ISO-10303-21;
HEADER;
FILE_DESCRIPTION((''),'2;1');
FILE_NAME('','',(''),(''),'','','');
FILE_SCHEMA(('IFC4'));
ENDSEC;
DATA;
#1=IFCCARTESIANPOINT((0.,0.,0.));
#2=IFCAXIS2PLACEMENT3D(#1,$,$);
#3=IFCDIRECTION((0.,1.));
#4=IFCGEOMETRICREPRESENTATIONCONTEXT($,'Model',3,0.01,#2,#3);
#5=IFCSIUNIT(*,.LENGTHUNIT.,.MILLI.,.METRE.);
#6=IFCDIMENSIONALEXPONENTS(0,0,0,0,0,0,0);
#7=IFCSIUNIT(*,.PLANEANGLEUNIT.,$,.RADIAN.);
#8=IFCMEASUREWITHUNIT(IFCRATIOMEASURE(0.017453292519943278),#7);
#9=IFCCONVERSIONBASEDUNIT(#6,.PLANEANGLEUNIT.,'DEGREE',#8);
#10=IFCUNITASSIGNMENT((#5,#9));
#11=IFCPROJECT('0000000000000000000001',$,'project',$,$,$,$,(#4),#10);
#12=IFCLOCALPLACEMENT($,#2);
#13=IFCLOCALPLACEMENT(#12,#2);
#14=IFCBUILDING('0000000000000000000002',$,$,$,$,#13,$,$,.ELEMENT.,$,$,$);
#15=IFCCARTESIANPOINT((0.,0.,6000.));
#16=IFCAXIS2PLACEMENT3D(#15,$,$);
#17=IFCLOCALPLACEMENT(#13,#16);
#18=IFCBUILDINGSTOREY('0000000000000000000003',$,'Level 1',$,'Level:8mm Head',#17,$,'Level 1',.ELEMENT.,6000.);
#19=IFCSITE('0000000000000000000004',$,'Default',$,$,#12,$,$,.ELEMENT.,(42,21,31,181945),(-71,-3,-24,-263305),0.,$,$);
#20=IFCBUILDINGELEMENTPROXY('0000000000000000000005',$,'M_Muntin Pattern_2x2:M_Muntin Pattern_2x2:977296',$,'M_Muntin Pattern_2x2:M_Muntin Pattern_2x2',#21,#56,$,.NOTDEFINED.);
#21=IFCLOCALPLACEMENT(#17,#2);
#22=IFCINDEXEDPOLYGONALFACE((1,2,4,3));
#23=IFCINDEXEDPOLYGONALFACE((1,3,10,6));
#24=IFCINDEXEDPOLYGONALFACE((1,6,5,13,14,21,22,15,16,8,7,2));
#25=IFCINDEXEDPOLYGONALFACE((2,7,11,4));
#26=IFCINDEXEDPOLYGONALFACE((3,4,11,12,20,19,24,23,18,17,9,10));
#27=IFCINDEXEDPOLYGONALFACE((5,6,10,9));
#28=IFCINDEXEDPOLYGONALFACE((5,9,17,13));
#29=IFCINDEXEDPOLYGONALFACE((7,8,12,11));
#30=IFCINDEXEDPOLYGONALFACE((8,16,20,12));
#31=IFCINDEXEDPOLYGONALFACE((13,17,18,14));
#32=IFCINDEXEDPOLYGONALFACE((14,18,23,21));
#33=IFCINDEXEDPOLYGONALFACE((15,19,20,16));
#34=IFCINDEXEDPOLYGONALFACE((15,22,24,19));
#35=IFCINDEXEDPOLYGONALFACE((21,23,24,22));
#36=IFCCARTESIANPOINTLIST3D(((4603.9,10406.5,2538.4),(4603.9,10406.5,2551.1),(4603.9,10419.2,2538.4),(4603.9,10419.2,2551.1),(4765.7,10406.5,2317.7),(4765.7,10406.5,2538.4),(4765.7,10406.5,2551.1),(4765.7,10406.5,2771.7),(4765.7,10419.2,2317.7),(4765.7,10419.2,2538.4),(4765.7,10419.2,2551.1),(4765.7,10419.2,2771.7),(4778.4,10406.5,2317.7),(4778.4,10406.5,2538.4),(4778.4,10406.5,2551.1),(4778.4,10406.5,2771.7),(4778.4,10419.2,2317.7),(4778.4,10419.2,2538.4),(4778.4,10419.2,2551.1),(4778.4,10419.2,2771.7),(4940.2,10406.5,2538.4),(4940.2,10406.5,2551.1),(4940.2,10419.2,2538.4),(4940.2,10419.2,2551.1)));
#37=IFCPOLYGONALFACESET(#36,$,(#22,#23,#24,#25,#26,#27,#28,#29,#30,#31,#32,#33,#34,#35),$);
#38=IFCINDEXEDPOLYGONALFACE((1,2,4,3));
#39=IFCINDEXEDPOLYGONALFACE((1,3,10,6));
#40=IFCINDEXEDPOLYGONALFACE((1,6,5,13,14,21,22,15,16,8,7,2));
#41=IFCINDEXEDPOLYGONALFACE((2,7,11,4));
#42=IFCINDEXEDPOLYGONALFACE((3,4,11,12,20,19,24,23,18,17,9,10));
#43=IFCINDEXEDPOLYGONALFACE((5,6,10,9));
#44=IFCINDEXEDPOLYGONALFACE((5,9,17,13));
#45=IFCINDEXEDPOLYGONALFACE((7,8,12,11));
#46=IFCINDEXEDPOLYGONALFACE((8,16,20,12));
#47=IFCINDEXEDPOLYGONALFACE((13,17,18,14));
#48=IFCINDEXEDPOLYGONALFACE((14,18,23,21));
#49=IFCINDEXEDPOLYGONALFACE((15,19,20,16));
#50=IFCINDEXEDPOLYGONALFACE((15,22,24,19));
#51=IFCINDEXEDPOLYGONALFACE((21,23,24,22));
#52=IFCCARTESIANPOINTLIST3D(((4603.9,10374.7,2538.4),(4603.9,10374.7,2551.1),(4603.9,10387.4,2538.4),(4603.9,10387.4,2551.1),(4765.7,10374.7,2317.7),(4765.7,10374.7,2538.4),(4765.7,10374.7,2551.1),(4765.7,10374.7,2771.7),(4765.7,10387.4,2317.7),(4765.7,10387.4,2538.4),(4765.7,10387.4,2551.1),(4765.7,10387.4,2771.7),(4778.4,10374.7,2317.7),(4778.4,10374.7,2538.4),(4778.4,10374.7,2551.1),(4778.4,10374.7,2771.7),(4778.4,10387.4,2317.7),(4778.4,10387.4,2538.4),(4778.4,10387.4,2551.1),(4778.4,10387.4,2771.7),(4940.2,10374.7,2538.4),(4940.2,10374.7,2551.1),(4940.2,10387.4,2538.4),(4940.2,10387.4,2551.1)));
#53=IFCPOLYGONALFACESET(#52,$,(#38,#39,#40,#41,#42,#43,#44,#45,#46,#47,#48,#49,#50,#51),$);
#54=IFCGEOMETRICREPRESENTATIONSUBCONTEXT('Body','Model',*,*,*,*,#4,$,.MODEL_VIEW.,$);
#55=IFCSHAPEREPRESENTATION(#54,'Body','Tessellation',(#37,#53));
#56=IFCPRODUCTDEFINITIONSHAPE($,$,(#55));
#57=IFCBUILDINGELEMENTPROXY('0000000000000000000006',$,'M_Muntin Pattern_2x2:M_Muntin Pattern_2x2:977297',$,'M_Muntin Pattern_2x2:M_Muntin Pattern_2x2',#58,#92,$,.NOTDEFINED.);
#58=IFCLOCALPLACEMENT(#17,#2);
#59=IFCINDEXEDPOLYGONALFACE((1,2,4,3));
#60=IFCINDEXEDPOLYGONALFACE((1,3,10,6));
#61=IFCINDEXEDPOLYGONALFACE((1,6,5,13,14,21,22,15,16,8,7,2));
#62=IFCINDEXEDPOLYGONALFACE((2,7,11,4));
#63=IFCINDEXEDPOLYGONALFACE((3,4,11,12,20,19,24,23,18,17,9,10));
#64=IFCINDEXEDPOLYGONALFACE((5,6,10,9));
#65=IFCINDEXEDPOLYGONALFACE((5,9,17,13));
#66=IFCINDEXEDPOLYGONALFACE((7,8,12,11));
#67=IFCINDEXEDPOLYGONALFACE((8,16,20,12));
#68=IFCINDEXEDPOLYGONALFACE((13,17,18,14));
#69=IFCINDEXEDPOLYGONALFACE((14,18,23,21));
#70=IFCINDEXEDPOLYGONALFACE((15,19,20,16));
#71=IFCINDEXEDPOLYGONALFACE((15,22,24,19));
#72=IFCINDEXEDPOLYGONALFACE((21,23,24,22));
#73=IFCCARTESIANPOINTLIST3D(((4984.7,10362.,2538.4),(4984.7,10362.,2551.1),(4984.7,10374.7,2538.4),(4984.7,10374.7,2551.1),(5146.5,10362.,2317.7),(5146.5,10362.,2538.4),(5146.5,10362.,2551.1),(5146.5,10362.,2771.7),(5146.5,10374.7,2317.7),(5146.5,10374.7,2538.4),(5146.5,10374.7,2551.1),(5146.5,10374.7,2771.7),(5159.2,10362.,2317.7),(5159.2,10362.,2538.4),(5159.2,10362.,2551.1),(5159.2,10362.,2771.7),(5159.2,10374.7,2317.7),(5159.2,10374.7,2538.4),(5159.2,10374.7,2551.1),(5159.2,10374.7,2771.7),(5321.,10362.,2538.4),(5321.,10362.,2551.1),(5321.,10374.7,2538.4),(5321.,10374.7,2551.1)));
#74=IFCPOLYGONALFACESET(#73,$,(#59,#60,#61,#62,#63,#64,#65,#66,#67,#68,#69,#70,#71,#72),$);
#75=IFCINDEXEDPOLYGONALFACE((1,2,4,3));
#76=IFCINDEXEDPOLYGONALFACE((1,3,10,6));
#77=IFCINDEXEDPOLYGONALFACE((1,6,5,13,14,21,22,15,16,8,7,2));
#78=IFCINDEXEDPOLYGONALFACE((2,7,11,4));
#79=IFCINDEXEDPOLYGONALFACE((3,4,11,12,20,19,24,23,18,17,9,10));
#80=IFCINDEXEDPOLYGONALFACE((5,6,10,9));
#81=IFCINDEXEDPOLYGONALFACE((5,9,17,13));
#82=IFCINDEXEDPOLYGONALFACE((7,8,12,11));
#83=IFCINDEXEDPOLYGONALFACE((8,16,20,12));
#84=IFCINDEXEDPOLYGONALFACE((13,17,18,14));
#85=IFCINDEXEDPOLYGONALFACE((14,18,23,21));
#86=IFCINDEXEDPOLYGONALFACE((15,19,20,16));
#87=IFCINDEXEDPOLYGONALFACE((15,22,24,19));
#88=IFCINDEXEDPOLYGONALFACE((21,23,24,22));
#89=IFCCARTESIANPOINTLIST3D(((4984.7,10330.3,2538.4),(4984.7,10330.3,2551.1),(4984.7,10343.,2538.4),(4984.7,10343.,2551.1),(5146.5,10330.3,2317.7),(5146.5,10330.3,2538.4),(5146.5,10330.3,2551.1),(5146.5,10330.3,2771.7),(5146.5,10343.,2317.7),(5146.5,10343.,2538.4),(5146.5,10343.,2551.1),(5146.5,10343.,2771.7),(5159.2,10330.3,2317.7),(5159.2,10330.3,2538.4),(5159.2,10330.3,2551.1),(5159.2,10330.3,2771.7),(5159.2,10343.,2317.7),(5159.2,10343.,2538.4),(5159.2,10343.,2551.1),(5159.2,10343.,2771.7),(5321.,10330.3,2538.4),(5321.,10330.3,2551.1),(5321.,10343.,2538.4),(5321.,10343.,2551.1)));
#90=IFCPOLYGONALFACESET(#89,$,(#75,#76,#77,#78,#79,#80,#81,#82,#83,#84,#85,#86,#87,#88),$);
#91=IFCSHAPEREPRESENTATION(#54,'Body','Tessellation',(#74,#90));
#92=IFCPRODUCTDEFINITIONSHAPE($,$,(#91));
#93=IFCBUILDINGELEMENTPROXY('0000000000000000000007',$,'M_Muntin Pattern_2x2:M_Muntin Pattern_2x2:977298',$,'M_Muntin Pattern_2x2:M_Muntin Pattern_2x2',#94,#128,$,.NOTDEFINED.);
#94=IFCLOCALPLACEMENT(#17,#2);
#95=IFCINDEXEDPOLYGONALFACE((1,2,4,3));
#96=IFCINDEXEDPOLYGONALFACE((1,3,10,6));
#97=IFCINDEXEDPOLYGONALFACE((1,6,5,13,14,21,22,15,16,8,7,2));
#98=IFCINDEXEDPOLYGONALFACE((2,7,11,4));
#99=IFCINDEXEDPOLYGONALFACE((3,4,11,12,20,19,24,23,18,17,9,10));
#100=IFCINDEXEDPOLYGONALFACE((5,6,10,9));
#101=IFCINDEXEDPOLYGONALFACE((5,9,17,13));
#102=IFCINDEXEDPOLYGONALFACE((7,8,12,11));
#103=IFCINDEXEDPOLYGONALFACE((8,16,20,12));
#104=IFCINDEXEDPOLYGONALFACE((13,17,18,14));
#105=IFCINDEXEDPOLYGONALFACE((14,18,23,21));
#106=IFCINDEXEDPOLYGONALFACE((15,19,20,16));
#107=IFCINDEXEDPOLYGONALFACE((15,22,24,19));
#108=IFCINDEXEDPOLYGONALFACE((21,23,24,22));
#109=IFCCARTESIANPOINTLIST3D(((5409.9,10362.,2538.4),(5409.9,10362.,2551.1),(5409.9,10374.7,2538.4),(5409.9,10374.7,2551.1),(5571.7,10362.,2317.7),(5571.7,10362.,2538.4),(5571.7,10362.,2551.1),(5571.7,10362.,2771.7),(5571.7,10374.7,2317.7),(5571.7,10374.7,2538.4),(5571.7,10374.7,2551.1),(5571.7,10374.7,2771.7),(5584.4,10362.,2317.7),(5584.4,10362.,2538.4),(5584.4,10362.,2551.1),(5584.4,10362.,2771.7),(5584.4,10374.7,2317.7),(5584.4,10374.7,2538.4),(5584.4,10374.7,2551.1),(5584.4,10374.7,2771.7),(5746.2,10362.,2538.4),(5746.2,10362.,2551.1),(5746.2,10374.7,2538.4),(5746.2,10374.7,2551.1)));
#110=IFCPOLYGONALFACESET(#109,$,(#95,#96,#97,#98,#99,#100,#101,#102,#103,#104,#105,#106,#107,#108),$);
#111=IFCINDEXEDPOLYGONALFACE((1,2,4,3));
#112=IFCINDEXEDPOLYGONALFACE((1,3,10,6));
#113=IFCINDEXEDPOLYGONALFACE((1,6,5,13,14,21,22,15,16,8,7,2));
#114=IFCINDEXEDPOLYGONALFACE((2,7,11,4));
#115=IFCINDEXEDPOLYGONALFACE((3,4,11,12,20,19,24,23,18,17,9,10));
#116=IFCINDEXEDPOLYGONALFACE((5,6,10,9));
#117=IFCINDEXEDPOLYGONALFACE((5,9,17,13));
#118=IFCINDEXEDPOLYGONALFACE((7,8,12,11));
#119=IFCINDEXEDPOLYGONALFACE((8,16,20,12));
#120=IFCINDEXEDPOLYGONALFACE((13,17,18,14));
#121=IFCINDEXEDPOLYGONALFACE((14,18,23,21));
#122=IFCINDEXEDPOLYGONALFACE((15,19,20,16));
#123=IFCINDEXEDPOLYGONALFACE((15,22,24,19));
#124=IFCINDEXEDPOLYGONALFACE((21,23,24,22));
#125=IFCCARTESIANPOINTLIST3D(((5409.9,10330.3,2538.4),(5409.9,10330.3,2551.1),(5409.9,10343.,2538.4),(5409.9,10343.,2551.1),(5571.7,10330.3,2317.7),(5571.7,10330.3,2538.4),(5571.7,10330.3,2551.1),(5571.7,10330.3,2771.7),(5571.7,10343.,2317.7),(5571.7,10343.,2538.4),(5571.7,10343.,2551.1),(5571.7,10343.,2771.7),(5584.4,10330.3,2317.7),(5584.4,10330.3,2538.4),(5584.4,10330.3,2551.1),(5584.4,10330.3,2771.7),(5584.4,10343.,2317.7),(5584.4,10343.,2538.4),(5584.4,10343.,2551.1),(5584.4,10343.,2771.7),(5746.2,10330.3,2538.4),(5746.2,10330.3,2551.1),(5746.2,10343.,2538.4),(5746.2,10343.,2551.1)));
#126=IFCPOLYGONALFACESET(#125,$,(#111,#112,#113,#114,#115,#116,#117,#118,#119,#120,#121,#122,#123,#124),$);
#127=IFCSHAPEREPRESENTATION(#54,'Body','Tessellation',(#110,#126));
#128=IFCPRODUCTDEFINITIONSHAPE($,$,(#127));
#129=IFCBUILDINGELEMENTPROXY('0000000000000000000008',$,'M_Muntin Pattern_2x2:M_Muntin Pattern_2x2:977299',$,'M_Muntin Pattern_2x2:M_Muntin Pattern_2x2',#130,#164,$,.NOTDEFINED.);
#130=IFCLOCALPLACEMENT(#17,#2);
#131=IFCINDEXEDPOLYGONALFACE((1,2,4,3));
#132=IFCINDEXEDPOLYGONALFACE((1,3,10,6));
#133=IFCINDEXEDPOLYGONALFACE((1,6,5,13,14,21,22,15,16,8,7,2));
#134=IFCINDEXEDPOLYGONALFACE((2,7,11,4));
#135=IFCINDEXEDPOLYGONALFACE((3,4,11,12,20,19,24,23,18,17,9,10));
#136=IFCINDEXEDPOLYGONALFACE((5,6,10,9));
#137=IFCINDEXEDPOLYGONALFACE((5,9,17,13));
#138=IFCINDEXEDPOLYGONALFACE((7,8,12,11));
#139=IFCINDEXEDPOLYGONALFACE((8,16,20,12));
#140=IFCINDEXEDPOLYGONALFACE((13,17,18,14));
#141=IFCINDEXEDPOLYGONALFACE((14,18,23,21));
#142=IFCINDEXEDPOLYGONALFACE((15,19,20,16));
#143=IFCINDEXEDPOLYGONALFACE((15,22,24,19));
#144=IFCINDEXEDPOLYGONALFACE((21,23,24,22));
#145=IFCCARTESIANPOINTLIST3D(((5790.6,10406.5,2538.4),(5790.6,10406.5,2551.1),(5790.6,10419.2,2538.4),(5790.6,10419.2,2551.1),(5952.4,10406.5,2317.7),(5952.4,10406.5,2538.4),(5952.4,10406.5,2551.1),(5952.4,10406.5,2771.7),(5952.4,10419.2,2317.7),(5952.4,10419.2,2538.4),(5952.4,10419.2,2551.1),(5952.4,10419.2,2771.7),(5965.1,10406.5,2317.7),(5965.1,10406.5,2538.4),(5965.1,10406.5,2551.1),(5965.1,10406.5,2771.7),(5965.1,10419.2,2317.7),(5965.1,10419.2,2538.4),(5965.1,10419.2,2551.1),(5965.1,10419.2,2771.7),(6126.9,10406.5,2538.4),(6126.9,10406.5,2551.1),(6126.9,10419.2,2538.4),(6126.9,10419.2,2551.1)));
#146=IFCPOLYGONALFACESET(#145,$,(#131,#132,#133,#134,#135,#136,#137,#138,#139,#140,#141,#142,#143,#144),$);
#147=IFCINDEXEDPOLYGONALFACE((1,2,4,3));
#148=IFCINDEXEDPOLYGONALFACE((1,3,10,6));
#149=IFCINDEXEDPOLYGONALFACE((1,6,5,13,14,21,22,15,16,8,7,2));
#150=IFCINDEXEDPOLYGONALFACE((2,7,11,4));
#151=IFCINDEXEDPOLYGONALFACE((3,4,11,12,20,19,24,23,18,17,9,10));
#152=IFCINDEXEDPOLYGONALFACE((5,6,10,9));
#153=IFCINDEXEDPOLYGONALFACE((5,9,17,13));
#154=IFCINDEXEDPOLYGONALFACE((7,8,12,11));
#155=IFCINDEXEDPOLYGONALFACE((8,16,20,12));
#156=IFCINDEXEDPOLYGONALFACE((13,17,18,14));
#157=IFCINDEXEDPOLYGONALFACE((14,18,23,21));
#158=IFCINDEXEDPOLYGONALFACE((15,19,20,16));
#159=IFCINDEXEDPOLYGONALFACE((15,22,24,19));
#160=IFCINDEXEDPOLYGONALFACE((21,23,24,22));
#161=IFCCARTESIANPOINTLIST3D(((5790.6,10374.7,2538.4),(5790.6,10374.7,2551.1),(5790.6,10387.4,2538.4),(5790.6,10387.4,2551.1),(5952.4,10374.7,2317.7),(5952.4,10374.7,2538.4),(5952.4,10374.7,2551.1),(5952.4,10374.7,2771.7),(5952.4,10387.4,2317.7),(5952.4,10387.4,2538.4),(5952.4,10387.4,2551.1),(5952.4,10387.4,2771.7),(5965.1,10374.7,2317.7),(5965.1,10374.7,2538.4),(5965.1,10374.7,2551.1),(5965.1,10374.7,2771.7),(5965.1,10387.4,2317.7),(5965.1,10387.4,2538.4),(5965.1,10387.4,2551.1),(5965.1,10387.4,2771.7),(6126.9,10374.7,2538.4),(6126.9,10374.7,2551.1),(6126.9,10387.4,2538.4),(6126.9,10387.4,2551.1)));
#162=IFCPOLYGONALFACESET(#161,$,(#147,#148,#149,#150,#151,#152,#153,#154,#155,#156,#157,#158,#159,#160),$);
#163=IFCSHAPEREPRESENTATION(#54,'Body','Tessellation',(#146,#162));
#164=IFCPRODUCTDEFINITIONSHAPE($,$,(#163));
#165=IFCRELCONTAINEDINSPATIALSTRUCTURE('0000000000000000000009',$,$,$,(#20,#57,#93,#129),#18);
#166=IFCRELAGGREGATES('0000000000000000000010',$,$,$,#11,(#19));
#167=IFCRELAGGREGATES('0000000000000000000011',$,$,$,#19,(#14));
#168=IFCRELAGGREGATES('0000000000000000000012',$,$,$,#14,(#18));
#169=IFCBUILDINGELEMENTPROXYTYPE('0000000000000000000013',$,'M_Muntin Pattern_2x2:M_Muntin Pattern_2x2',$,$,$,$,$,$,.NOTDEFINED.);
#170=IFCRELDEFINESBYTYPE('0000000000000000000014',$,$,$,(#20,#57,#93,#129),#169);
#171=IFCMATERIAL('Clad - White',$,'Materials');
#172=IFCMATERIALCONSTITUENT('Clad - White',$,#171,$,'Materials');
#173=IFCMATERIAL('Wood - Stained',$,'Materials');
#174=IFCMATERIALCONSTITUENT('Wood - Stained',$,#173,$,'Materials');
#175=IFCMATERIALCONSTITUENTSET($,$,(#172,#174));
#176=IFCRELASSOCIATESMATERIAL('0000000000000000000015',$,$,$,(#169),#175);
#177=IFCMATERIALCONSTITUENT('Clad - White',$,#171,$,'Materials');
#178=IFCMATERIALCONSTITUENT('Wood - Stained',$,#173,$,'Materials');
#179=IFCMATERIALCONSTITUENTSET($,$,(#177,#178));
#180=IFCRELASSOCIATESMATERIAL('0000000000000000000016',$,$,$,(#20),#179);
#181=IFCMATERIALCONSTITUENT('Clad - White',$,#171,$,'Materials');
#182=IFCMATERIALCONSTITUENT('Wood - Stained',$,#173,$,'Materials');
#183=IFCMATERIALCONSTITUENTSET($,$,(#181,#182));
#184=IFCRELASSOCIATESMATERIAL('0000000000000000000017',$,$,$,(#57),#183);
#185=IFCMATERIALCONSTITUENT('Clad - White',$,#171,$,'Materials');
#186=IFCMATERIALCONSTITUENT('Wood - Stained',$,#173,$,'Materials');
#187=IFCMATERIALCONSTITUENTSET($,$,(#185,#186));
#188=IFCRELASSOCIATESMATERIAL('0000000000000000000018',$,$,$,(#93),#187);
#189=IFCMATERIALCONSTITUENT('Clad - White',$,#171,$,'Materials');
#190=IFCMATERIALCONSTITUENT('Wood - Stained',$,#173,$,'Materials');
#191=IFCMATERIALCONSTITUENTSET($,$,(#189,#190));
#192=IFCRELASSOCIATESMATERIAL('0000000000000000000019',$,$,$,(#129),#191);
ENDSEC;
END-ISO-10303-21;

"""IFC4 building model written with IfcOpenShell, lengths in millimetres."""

from ifc_helpers import new_model, entity, si_unit, converted_unit, direction, frame, origin, place, context, subcontext, project, spatial, indexed_curve, outline, extrude, source, transform, mapped, material, constituent, constituent_set, type_object, type_shapes, element, save


model = new_model("IFC4")

# Units and contexts
model_context = context("Model", 3, precision=0.01, world=origin(), true_north=direction((0.0, 1.0)))
body_context = subcontext(model_context, "Body", "Model", "MODEL_VIEW")
ifc_project = project(units=[si_unit("LENGTHUNIT", "METRE", prefix="MILLI"), converted_unit("PLANEANGLEUNIT", "DEGREE", entity("IfcRatioMeasure", 0.017453292519943278), si_unit("PLANEANGLEUNIT", "RADIAN"), dimensions=[0, 0, 0, 0, 0, 0, 0])], contexts=[model_context])

# Site, building, storey
site_placement = place(None, origin())
site = spatial("IfcSite", under=ifc_project, at=site_placement, Name="Default", CompositionType="ELEMENT", RefLatitude=(42, 21, 31, 181945), RefLongitude=(-71, -3, -24, -263305), RefElevation=0.0)
building_placement = place(site_placement, origin())
building = spatial("IfcBuilding", under=site, at=building_placement, CompositionType="ELEMENT")
storey_placement = place(building_placement, frame((0.0, 0.0, 6000.0)))
storey = spatial("IfcBuildingStorey", under=building, at=storey_placement, Name="Level 1", ObjectType="Level:8mm Head", LongName="Level 1", CompositionType="ELEMENT", Elevation=6000.0)

# Building element proxies
ifc_material_1 = material(Name="Clad - White", Category="Materials")
ifc_constituent_1 = constituent(ifc_material_1, Name="Clad - White", Category="Materials")
ifc_material_2 = material(Name="Wood - Stained", Category="Materials")
ifc_constituent_2 = constituent(ifc_material_2, Name="Wood - Stained", Category="Materials")
ifc_constituent_set_1 = constituent_set(constituents=[ifc_constituent_1, ifc_constituent_2])
ifc_constituent_3 = constituent(ifc_material_1, Name="Clad - White", Category="Materials")
ifc_constituent_4 = constituent(ifc_material_2, Name="Wood - Stained", Category="Materials")
ifc_constituent_set_2 = constituent_set(constituents=[ifc_constituent_3, ifc_constituent_4])
building_element_proxy_type_1 = type_object("IfcBuildingElementProxyType", Name="M_Muntin Pattern_2x2:M_Muntin Pattern_2x2", PredefinedType="NOTDEFINED", material=ifc_constituent_set_2)
shared_shape_1 = source(origin(), body_context, "Body", "SweptSolid", [
    extrude(outline(indexed_curve([(6.4, -6.4), (227.0, -6.4), (227.0, 6.3), (6.4, 6.3), (6.4, 168.2), (-6.3, 168.2), (-6.3, 6.3), (-227.0, 6.3), (-227.0, -6.4), (-6.3, -6.4), (-6.3, -168.1), (6.4, -168.1), (6.4, -6.4)], self_intersect=False)), frame((0.0, 9.5, 227.0), z_axis=(0.0, 1.0, 0.0), x_axis=(0.0, 0.0, 1.0)), (0.0, 0.0, 1.0), 12.7),
    extrude(outline(indexed_curve([(6.4, -6.4), (227.0, -6.4), (227.0, 6.3), (6.4, 6.3), (6.4, 168.2), (-6.3, 168.2), (-6.3, 6.3), (-227.0, 6.3), (-227.0, -6.4), (-6.3, -6.4), (-6.3, -168.1), (6.4, -168.1), (6.4, -6.4)], self_intersect=False)), frame((0.0, -22.2, 227.0), z_axis=(0.0, 1.0, 0.0), x_axis=(0.0, 0.0, 1.0)), (0.0, 0.0, 1.0), 12.7),
])
type_shapes(building_element_proxy_type_1, [shared_shape_1])
proxy_1_placement = place(storey_placement, frame((4772.1, 10396.9, 2317.7)))
element("IfcBuildingElementProxy", 1, at=proxy_1_placement, inside=storey, type_object=building_element_proxy_type_1, material=ifc_constituent_set_1, Name="M_Muntin Pattern_2x2:M_Muntin Pattern_2x2:977296", ObjectType="M_Muntin Pattern_2x2:M_Muntin Pattern_2x2", PredefinedType="NOTDEFINED", context=body_context, shape_type="MappedRepresentation", body=[
    mapped(shared_shape_1, transform((0.0, 0.0, 0.0), scale=1.0)),
])
ifc_constituent_5 = constituent(ifc_material_1, Name="Clad - White", Category="Materials")
ifc_constituent_6 = constituent(ifc_material_2, Name="Wood - Stained", Category="Materials")
ifc_constituent_set_3 = constituent_set(constituents=[ifc_constituent_5, ifc_constituent_6])
proxy_2_placement = place(storey_placement, frame((5152.8, 10352.5, 2317.7)))
element("IfcBuildingElementProxy", 2, at=proxy_2_placement, inside=storey, type_object=building_element_proxy_type_1, material=ifc_constituent_set_3, Name="M_Muntin Pattern_2x2:M_Muntin Pattern_2x2:977297", ObjectType="M_Muntin Pattern_2x2:M_Muntin Pattern_2x2", PredefinedType="NOTDEFINED", context=body_context, shape_type="MappedRepresentation", body=[
    mapped(shared_shape_1, transform((0.0, 0.0, 0.0), scale=1.0)),
])
ifc_constituent_7 = constituent(ifc_material_1, Name="Clad - White", Category="Materials")
ifc_constituent_8 = constituent(ifc_material_2, Name="Wood - Stained", Category="Materials")
ifc_constituent_set_4 = constituent_set(constituents=[ifc_constituent_7, ifc_constituent_8])
proxy_3_placement = place(storey_placement, frame((5578.0, 10352.5, 2317.7)))
element("IfcBuildingElementProxy", 3, at=proxy_3_placement, inside=storey, type_object=building_element_proxy_type_1, material=ifc_constituent_set_4, Name="M_Muntin Pattern_2x2:M_Muntin Pattern_2x2:977298", ObjectType="M_Muntin Pattern_2x2:M_Muntin Pattern_2x2", PredefinedType="NOTDEFINED", context=body_context, shape_type="MappedRepresentation", body=[
    mapped(shared_shape_1, transform((0.0, 0.0, 0.0), scale=1.0)),
])
ifc_constituent_9 = constituent(ifc_material_1, Name="Clad - White", Category="Materials")
ifc_constituent_10 = constituent(ifc_material_2, Name="Wood - Stained", Category="Materials")
ifc_constituent_set_5 = constituent_set(constituents=[ifc_constituent_9, ifc_constituent_10])
proxy_4_placement = place(storey_placement, frame((5958.8, 10396.9, 2317.7)))
element("IfcBuildingElementProxy", 4, at=proxy_4_placement, inside=storey, type_object=building_element_proxy_type_1, material=ifc_constituent_set_5, Name="M_Muntin Pattern_2x2:M_Muntin Pattern_2x2:977299", ObjectType="M_Muntin Pattern_2x2:M_Muntin Pattern_2x2", PredefinedType="NOTDEFINED", context=body_context, shape_type="MappedRepresentation", body=[
    mapped(shared_shape_1, transform((0.0, 0.0, 0.0), scale=1.0)),
])

save(model, "model.ifc")
